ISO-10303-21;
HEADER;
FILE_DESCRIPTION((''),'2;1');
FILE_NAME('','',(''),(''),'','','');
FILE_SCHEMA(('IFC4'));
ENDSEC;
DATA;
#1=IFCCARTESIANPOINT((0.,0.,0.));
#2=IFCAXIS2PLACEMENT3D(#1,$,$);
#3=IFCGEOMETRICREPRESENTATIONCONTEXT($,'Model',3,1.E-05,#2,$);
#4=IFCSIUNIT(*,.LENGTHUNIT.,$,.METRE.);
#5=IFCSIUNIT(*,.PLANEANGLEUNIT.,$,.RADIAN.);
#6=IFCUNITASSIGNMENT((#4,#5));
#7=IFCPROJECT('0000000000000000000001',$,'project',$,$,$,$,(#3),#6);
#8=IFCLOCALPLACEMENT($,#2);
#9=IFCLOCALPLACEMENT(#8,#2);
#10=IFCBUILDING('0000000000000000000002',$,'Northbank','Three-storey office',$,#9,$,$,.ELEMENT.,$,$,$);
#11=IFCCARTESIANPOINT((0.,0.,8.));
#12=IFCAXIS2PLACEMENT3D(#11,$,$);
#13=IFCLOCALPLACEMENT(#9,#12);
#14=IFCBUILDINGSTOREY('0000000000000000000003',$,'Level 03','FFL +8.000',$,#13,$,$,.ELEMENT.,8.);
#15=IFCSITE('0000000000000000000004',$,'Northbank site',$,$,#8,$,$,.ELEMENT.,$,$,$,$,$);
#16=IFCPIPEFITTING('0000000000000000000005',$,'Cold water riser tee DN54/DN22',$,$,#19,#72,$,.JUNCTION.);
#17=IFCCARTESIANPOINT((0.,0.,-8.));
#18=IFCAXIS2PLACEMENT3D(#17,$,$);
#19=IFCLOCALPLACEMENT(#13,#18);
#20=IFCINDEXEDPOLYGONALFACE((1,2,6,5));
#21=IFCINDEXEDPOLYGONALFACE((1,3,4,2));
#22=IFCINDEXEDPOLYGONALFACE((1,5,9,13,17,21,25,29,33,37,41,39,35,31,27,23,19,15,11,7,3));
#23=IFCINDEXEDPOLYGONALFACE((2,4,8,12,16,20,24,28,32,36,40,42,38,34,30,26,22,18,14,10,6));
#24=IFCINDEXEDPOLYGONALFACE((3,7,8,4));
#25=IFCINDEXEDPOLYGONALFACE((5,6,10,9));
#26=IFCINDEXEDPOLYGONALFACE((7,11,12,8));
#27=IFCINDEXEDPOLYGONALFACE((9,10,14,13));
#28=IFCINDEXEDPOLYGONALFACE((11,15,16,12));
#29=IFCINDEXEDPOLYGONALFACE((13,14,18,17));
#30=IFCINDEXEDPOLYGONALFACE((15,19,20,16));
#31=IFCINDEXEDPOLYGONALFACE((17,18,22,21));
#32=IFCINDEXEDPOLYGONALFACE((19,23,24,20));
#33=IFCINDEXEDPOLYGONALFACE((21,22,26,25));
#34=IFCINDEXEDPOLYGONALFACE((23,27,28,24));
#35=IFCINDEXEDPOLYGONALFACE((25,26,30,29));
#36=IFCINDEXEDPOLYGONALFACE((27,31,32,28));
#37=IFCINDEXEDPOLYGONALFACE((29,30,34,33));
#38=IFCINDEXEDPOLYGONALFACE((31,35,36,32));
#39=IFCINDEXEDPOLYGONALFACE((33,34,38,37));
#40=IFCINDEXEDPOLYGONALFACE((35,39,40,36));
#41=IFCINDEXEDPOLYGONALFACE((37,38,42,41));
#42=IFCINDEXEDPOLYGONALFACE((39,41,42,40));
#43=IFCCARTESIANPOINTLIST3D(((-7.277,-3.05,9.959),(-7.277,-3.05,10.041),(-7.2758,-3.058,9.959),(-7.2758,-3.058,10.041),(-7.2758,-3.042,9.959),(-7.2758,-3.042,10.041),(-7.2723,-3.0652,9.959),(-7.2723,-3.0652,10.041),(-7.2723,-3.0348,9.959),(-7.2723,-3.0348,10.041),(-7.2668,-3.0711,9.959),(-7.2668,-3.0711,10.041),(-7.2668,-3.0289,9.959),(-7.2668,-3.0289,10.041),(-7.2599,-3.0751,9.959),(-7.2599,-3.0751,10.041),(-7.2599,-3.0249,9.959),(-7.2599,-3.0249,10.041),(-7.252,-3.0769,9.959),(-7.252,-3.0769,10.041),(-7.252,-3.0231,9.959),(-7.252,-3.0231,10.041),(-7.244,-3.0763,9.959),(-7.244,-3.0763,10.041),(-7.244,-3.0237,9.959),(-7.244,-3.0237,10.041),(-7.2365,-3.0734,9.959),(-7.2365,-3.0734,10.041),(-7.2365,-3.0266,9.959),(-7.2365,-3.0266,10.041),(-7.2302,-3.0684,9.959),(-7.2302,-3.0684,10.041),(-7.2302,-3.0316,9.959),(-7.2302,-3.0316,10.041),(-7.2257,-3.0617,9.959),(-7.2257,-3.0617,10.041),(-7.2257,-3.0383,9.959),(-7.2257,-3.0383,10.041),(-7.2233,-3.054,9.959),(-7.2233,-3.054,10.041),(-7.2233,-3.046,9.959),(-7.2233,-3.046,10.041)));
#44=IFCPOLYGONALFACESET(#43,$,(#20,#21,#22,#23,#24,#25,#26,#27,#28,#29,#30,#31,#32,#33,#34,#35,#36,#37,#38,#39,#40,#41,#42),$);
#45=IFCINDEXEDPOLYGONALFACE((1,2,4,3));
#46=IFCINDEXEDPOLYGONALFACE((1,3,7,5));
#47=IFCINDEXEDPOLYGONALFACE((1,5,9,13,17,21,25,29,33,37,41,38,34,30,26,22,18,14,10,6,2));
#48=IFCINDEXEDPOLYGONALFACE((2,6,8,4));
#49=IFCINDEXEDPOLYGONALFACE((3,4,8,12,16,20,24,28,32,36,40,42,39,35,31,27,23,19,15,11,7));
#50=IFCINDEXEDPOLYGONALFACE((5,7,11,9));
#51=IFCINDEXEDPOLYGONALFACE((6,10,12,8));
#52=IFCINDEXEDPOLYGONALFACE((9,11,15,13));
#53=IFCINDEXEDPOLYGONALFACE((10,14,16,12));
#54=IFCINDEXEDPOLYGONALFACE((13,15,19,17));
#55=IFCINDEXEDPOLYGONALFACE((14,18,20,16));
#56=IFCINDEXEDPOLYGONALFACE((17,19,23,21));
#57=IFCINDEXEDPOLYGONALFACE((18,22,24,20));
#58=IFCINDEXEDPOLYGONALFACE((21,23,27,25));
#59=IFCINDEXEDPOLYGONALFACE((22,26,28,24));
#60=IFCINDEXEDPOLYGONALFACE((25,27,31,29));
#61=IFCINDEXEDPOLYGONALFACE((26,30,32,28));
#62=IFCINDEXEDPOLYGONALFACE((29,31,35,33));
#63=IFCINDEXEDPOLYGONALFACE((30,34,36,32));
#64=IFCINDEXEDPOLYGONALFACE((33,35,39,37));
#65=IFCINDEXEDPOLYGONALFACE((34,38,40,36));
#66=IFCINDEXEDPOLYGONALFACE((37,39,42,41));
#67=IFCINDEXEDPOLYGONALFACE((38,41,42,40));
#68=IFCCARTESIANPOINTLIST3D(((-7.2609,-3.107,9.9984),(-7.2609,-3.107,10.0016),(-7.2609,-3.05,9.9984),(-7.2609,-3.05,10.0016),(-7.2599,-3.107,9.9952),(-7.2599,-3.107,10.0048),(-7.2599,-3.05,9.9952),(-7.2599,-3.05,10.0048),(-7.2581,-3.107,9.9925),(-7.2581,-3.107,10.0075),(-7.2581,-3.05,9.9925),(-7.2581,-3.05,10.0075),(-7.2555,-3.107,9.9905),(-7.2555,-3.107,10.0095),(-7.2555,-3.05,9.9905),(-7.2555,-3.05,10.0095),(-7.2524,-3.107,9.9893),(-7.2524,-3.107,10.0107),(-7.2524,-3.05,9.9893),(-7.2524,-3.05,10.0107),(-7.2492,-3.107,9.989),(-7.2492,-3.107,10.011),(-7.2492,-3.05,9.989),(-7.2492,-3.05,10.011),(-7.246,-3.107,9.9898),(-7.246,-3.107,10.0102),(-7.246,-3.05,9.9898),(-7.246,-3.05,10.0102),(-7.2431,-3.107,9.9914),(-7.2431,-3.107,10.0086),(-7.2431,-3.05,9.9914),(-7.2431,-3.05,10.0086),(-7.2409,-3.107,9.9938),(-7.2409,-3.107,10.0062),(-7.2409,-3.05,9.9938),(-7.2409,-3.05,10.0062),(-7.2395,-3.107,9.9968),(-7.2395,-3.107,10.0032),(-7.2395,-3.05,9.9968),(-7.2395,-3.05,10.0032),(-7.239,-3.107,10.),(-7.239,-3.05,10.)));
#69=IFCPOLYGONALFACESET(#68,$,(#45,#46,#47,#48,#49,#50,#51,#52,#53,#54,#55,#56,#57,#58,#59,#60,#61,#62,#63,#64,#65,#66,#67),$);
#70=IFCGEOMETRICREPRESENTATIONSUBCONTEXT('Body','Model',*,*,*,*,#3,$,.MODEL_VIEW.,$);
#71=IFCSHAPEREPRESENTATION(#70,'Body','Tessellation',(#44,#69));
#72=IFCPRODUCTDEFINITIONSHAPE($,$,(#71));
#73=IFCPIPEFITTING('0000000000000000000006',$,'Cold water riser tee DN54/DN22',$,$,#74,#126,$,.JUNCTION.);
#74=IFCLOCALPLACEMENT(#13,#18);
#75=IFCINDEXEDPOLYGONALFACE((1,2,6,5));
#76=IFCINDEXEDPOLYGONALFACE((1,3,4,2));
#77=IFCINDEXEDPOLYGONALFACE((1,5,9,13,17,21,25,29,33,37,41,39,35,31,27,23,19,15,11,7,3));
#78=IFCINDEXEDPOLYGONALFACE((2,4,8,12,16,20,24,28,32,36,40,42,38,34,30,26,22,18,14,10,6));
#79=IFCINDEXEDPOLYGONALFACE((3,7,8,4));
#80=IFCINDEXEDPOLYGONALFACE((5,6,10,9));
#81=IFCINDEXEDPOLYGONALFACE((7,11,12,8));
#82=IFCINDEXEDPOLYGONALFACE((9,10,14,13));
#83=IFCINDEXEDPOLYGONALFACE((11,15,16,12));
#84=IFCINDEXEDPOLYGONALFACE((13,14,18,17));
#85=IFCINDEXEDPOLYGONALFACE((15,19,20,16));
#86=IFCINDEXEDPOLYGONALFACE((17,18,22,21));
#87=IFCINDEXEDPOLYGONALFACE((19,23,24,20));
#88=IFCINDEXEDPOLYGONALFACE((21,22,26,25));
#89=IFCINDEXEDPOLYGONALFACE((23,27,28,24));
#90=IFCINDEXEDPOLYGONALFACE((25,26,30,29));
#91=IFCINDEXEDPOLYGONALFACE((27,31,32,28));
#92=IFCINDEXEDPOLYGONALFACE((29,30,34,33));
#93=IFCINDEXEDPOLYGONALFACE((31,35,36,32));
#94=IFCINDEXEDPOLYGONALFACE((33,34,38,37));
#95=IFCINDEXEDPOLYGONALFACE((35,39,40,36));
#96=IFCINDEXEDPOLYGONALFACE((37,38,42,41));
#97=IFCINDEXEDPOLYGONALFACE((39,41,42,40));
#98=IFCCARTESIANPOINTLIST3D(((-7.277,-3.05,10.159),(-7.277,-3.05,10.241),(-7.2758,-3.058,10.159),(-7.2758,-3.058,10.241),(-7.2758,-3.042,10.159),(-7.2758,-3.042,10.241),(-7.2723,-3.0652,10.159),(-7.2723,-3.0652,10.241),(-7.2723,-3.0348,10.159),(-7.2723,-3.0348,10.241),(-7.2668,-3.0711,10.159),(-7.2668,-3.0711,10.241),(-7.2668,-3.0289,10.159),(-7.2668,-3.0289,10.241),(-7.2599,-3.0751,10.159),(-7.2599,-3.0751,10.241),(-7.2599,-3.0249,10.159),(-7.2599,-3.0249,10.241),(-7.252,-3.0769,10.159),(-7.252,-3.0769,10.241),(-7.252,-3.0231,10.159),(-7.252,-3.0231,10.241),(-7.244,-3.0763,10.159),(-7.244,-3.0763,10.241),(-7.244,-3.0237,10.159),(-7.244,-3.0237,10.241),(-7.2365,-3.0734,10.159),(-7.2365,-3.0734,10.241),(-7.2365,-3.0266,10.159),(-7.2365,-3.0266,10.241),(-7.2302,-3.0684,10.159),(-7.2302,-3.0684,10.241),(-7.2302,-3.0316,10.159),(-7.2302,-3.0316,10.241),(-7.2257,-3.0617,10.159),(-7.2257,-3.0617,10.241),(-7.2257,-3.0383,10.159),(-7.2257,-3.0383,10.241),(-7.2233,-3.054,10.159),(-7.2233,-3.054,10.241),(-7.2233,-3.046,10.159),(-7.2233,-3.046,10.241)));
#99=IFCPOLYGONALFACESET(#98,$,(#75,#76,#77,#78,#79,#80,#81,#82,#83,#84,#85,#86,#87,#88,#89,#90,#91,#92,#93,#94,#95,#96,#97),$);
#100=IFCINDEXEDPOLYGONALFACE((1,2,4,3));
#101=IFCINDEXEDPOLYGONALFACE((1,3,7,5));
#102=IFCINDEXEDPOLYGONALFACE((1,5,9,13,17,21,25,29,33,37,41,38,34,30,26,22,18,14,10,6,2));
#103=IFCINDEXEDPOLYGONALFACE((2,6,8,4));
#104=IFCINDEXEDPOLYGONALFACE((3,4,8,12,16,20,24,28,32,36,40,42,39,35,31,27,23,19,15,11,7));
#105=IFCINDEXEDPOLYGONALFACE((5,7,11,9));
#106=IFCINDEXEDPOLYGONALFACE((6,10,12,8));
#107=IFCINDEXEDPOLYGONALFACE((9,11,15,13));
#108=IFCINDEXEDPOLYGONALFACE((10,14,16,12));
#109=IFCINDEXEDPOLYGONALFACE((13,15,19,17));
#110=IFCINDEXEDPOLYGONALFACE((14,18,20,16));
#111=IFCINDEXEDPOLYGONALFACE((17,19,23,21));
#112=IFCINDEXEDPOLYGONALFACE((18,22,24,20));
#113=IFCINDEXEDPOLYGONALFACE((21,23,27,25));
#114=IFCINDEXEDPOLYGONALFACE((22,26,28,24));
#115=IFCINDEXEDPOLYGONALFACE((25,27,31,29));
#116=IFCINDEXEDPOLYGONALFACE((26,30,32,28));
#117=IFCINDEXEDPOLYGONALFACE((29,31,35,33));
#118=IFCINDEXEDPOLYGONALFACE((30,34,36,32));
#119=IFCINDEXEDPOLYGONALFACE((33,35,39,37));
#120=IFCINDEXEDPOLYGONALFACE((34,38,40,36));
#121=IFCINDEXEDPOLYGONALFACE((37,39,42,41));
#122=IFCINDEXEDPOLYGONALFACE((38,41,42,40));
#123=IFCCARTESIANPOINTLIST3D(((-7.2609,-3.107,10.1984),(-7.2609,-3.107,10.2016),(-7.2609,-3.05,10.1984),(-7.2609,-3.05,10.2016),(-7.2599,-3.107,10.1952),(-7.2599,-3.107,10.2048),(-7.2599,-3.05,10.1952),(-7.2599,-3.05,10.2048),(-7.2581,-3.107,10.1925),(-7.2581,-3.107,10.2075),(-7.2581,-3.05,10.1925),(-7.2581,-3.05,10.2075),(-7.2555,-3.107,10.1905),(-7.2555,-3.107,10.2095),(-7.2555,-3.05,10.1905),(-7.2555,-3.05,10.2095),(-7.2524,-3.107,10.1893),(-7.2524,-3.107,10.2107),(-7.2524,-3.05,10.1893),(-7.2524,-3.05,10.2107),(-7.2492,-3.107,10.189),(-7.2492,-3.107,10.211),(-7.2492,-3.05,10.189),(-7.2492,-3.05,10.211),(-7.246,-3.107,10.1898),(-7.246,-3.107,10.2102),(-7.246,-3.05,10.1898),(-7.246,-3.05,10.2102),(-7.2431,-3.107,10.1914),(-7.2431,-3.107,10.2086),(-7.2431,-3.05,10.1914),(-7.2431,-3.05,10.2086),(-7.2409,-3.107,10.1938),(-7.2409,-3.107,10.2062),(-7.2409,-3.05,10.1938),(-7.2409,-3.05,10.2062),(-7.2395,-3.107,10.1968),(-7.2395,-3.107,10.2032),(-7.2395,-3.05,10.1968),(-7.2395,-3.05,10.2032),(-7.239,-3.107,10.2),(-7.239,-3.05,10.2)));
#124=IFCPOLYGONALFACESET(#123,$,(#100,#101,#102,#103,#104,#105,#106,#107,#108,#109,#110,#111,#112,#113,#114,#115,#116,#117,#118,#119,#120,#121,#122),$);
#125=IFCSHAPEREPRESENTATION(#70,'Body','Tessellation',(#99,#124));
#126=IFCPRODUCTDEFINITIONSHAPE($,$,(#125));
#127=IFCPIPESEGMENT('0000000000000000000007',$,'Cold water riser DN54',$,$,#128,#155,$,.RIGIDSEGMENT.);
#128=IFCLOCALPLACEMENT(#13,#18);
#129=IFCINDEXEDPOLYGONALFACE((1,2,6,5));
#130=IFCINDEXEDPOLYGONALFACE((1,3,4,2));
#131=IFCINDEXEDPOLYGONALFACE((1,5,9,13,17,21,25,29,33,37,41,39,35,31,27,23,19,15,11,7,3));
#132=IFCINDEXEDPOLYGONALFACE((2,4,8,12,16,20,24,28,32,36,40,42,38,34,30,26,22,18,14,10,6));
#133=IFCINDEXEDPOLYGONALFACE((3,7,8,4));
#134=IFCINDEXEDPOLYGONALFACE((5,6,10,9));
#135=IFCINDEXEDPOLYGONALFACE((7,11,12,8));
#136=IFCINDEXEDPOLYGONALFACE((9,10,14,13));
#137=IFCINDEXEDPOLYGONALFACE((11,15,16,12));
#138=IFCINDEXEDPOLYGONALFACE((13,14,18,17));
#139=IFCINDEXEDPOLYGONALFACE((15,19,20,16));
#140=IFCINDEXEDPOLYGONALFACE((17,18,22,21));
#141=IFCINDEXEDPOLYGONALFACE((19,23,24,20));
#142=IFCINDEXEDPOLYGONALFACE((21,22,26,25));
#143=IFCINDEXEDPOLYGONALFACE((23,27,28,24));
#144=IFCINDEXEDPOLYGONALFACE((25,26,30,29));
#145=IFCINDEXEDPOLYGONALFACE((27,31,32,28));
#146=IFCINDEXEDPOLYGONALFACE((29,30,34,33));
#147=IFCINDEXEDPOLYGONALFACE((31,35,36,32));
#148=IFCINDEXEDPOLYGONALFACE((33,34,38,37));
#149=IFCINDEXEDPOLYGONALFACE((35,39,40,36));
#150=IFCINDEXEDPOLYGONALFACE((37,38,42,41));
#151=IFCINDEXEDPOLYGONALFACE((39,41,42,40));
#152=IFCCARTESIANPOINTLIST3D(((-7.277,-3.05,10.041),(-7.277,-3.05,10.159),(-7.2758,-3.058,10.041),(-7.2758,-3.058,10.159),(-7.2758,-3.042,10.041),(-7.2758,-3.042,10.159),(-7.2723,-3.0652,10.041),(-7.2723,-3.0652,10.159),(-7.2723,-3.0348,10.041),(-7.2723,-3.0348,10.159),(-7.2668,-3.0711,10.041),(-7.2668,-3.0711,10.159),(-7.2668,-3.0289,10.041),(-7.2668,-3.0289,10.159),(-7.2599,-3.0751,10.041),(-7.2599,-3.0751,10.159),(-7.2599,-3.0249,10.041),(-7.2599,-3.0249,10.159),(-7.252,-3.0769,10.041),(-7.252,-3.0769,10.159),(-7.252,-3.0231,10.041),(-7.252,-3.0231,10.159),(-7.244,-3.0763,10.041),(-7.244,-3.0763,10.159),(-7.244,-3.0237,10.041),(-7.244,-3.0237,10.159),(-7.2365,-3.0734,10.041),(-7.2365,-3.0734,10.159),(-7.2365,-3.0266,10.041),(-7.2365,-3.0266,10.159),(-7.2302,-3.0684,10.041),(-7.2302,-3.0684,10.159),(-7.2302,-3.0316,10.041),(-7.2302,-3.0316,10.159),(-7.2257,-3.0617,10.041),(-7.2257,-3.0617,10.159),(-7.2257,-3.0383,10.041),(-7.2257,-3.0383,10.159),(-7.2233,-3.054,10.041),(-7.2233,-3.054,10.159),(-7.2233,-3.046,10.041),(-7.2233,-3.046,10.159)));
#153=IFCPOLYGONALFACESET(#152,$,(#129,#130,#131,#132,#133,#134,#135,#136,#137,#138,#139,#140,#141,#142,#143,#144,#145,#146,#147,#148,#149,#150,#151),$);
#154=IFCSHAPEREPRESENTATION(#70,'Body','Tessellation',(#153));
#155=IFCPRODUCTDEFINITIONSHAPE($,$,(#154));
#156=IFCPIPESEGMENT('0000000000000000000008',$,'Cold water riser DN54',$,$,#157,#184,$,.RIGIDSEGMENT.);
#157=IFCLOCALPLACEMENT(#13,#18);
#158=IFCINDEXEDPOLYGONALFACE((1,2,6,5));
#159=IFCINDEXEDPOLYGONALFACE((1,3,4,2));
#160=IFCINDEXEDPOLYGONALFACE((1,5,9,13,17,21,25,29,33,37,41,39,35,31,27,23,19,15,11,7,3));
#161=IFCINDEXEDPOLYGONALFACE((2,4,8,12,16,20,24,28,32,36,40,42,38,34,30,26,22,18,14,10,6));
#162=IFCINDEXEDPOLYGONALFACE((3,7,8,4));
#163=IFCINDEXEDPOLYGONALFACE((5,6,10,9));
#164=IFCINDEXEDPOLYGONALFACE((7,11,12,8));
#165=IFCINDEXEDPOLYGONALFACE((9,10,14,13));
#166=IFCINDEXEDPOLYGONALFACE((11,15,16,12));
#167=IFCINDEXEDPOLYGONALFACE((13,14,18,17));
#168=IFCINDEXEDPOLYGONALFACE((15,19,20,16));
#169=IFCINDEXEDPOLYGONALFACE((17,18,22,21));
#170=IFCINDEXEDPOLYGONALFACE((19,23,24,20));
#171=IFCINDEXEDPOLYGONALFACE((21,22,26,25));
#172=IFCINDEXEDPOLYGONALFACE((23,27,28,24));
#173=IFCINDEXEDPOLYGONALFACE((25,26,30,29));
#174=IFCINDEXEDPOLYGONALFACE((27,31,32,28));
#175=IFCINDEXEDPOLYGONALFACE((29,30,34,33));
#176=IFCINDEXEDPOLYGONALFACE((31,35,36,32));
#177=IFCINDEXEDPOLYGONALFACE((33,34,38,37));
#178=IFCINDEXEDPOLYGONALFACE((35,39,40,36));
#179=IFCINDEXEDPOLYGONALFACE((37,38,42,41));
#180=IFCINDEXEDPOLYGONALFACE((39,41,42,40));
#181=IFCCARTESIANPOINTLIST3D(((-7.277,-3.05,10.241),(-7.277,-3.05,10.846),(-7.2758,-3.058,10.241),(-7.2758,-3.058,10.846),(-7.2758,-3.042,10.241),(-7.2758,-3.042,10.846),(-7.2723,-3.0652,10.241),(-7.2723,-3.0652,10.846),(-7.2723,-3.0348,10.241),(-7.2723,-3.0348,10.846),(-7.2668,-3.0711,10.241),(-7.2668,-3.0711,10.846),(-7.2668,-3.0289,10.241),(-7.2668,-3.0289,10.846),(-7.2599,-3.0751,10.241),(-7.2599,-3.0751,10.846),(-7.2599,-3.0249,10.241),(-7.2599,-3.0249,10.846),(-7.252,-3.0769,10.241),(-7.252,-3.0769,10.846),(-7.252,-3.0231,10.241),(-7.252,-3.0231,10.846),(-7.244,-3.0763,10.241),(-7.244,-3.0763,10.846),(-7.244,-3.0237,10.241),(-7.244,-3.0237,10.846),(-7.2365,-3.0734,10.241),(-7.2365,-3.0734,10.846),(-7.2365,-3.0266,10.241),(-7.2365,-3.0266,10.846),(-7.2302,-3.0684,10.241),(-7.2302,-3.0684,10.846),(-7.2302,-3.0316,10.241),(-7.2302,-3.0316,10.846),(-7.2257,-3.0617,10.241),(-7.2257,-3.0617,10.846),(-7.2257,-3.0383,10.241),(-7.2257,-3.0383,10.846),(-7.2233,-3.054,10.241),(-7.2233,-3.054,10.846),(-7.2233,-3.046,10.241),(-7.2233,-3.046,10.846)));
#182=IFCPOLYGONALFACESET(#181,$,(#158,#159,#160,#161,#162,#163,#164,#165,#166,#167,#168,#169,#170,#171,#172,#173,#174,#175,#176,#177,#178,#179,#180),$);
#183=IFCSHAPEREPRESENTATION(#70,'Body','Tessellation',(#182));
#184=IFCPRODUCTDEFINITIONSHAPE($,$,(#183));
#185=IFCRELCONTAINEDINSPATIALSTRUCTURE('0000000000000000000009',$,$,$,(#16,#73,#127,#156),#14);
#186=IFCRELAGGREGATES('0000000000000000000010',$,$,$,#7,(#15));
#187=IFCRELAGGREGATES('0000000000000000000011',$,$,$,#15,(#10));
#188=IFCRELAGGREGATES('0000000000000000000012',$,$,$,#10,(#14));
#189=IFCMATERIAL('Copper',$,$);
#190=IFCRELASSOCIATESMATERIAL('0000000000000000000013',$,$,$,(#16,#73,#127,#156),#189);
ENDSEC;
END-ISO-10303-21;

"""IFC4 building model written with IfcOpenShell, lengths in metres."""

from ifc_helpers import new_model, si_unit, frame, origin, place, context, subcontext, project, spatial, circle, extrude, material, element, save


model = new_model("IFC4")

# Units and contexts
model_context = context("Model", 3, precision=1e-05, world=origin())
body_context = subcontext(model_context, "Body", "Model", "MODEL_VIEW")
ifc_project = project(units=[si_unit("LENGTHUNIT", "METRE"), si_unit("PLANEANGLEUNIT", "RADIAN")], contexts=[model_context])

# Site, building, storey
site_placement = place(None, origin())
site = spatial("IfcSite", under=ifc_project, at=site_placement, Name="Northbank site", CompositionType="ELEMENT")
building_placement = place(site_placement, origin())
building = spatial("IfcBuilding", under=site, at=building_placement, Name="Northbank", Description="Three-storey office", CompositionType="ELEMENT")
storey_placement = place(building_placement, frame((0.0, 0.0, 8.0)))
storey = spatial("IfcBuildingStorey", under=building, at=storey_placement, Name="Level 03", Description="FFL +8.000", CompositionType="ELEMENT", Elevation=8.0)

# Pipe fittings
ifc_material_1 = material(Name="Copper")
pipe_fitting_1_placement = place(storey_placement, frame((0.0, 0.0, -8.0)))
element("IfcPipeFitting", 1, at=pipe_fitting_1_placement, inside=storey, material=ifc_material_1, Name="Cold water riser tee DN54/DN22", PredefinedType="JUNCTION", context=body_context, shape_type="SweptSolid", body=[
    extrude(circle(Radius=0.027), frame((-7.25, -3.05, 9.959), z_axis=(0.0, 0.0, 1.0), x_axis=(-1.0, 0.0, 0.0)), (0.0, 0.0, 1.0), 0.082),
    extrude(circle(Radius=0.011), frame((-7.25, -3.05, 10.0), z_axis=(0.0, -1.0, 0.0), x_axis=(1.0, 0.0, 0.0)), (0.0, 0.0, 1.0), 0.057),
])
pipe_fitting_2_placement = place(storey_placement, frame((0.0, 0.0, -8.0)))
element("IfcPipeFitting", 2, at=pipe_fitting_2_placement, inside=storey, material=ifc_material_1, Name="Cold water riser tee DN54/DN22", PredefinedType="JUNCTION", context=body_context, shape_type="SweptSolid", body=[
    extrude(circle(Radius=0.027), frame((-7.25, -3.05, 10.159), z_axis=(0.0, 0.0, 1.0), x_axis=(-1.0, 0.0, 0.0)), (0.0, 0.0, 1.0), 0.082),
    extrude(circle(Radius=0.011), frame((-7.25, -3.05, 10.2), z_axis=(0.0, -1.0, 0.0), x_axis=(1.0, 0.0, 0.0)), (0.0, 0.0, 1.0), 0.057),
])

# Pipe segments
pipe_segment_1_placement = place(storey_placement, frame((0.0, 0.0, -8.0)))
element("IfcPipeSegment", 3, at=pipe_segment_1_placement, inside=storey, material=ifc_material_1, Name="Cold water riser DN54", PredefinedType="RIGIDSEGMENT", context=body_context, shape_type="SweptSolid", body=[
    extrude(circle(Radius=0.027), frame((-7.25, -3.05, 10.041), z_axis=(0.0, 0.0, 1.0), x_axis=(-1.0, 0.0, 0.0)), (0.0, 0.0, 1.0), 0.118),
])
pipe_segment_2_placement = place(storey_placement, frame((0.0, 0.0, -8.0)))
element("IfcPipeSegment", 4, at=pipe_segment_2_placement, inside=storey, material=ifc_material_1, Name="Cold water riser DN54", PredefinedType="RIGIDSEGMENT", context=body_context, shape_type="SweptSolid", body=[
    extrude(circle(Radius=0.027), frame((-7.25, -3.05, 10.241), z_axis=(0.0, 0.0, 1.0), x_axis=(-1.0, 0.0, 0.0)), (0.0, 0.0, 1.0), 0.605),
])

save(model, "model.ifc")
